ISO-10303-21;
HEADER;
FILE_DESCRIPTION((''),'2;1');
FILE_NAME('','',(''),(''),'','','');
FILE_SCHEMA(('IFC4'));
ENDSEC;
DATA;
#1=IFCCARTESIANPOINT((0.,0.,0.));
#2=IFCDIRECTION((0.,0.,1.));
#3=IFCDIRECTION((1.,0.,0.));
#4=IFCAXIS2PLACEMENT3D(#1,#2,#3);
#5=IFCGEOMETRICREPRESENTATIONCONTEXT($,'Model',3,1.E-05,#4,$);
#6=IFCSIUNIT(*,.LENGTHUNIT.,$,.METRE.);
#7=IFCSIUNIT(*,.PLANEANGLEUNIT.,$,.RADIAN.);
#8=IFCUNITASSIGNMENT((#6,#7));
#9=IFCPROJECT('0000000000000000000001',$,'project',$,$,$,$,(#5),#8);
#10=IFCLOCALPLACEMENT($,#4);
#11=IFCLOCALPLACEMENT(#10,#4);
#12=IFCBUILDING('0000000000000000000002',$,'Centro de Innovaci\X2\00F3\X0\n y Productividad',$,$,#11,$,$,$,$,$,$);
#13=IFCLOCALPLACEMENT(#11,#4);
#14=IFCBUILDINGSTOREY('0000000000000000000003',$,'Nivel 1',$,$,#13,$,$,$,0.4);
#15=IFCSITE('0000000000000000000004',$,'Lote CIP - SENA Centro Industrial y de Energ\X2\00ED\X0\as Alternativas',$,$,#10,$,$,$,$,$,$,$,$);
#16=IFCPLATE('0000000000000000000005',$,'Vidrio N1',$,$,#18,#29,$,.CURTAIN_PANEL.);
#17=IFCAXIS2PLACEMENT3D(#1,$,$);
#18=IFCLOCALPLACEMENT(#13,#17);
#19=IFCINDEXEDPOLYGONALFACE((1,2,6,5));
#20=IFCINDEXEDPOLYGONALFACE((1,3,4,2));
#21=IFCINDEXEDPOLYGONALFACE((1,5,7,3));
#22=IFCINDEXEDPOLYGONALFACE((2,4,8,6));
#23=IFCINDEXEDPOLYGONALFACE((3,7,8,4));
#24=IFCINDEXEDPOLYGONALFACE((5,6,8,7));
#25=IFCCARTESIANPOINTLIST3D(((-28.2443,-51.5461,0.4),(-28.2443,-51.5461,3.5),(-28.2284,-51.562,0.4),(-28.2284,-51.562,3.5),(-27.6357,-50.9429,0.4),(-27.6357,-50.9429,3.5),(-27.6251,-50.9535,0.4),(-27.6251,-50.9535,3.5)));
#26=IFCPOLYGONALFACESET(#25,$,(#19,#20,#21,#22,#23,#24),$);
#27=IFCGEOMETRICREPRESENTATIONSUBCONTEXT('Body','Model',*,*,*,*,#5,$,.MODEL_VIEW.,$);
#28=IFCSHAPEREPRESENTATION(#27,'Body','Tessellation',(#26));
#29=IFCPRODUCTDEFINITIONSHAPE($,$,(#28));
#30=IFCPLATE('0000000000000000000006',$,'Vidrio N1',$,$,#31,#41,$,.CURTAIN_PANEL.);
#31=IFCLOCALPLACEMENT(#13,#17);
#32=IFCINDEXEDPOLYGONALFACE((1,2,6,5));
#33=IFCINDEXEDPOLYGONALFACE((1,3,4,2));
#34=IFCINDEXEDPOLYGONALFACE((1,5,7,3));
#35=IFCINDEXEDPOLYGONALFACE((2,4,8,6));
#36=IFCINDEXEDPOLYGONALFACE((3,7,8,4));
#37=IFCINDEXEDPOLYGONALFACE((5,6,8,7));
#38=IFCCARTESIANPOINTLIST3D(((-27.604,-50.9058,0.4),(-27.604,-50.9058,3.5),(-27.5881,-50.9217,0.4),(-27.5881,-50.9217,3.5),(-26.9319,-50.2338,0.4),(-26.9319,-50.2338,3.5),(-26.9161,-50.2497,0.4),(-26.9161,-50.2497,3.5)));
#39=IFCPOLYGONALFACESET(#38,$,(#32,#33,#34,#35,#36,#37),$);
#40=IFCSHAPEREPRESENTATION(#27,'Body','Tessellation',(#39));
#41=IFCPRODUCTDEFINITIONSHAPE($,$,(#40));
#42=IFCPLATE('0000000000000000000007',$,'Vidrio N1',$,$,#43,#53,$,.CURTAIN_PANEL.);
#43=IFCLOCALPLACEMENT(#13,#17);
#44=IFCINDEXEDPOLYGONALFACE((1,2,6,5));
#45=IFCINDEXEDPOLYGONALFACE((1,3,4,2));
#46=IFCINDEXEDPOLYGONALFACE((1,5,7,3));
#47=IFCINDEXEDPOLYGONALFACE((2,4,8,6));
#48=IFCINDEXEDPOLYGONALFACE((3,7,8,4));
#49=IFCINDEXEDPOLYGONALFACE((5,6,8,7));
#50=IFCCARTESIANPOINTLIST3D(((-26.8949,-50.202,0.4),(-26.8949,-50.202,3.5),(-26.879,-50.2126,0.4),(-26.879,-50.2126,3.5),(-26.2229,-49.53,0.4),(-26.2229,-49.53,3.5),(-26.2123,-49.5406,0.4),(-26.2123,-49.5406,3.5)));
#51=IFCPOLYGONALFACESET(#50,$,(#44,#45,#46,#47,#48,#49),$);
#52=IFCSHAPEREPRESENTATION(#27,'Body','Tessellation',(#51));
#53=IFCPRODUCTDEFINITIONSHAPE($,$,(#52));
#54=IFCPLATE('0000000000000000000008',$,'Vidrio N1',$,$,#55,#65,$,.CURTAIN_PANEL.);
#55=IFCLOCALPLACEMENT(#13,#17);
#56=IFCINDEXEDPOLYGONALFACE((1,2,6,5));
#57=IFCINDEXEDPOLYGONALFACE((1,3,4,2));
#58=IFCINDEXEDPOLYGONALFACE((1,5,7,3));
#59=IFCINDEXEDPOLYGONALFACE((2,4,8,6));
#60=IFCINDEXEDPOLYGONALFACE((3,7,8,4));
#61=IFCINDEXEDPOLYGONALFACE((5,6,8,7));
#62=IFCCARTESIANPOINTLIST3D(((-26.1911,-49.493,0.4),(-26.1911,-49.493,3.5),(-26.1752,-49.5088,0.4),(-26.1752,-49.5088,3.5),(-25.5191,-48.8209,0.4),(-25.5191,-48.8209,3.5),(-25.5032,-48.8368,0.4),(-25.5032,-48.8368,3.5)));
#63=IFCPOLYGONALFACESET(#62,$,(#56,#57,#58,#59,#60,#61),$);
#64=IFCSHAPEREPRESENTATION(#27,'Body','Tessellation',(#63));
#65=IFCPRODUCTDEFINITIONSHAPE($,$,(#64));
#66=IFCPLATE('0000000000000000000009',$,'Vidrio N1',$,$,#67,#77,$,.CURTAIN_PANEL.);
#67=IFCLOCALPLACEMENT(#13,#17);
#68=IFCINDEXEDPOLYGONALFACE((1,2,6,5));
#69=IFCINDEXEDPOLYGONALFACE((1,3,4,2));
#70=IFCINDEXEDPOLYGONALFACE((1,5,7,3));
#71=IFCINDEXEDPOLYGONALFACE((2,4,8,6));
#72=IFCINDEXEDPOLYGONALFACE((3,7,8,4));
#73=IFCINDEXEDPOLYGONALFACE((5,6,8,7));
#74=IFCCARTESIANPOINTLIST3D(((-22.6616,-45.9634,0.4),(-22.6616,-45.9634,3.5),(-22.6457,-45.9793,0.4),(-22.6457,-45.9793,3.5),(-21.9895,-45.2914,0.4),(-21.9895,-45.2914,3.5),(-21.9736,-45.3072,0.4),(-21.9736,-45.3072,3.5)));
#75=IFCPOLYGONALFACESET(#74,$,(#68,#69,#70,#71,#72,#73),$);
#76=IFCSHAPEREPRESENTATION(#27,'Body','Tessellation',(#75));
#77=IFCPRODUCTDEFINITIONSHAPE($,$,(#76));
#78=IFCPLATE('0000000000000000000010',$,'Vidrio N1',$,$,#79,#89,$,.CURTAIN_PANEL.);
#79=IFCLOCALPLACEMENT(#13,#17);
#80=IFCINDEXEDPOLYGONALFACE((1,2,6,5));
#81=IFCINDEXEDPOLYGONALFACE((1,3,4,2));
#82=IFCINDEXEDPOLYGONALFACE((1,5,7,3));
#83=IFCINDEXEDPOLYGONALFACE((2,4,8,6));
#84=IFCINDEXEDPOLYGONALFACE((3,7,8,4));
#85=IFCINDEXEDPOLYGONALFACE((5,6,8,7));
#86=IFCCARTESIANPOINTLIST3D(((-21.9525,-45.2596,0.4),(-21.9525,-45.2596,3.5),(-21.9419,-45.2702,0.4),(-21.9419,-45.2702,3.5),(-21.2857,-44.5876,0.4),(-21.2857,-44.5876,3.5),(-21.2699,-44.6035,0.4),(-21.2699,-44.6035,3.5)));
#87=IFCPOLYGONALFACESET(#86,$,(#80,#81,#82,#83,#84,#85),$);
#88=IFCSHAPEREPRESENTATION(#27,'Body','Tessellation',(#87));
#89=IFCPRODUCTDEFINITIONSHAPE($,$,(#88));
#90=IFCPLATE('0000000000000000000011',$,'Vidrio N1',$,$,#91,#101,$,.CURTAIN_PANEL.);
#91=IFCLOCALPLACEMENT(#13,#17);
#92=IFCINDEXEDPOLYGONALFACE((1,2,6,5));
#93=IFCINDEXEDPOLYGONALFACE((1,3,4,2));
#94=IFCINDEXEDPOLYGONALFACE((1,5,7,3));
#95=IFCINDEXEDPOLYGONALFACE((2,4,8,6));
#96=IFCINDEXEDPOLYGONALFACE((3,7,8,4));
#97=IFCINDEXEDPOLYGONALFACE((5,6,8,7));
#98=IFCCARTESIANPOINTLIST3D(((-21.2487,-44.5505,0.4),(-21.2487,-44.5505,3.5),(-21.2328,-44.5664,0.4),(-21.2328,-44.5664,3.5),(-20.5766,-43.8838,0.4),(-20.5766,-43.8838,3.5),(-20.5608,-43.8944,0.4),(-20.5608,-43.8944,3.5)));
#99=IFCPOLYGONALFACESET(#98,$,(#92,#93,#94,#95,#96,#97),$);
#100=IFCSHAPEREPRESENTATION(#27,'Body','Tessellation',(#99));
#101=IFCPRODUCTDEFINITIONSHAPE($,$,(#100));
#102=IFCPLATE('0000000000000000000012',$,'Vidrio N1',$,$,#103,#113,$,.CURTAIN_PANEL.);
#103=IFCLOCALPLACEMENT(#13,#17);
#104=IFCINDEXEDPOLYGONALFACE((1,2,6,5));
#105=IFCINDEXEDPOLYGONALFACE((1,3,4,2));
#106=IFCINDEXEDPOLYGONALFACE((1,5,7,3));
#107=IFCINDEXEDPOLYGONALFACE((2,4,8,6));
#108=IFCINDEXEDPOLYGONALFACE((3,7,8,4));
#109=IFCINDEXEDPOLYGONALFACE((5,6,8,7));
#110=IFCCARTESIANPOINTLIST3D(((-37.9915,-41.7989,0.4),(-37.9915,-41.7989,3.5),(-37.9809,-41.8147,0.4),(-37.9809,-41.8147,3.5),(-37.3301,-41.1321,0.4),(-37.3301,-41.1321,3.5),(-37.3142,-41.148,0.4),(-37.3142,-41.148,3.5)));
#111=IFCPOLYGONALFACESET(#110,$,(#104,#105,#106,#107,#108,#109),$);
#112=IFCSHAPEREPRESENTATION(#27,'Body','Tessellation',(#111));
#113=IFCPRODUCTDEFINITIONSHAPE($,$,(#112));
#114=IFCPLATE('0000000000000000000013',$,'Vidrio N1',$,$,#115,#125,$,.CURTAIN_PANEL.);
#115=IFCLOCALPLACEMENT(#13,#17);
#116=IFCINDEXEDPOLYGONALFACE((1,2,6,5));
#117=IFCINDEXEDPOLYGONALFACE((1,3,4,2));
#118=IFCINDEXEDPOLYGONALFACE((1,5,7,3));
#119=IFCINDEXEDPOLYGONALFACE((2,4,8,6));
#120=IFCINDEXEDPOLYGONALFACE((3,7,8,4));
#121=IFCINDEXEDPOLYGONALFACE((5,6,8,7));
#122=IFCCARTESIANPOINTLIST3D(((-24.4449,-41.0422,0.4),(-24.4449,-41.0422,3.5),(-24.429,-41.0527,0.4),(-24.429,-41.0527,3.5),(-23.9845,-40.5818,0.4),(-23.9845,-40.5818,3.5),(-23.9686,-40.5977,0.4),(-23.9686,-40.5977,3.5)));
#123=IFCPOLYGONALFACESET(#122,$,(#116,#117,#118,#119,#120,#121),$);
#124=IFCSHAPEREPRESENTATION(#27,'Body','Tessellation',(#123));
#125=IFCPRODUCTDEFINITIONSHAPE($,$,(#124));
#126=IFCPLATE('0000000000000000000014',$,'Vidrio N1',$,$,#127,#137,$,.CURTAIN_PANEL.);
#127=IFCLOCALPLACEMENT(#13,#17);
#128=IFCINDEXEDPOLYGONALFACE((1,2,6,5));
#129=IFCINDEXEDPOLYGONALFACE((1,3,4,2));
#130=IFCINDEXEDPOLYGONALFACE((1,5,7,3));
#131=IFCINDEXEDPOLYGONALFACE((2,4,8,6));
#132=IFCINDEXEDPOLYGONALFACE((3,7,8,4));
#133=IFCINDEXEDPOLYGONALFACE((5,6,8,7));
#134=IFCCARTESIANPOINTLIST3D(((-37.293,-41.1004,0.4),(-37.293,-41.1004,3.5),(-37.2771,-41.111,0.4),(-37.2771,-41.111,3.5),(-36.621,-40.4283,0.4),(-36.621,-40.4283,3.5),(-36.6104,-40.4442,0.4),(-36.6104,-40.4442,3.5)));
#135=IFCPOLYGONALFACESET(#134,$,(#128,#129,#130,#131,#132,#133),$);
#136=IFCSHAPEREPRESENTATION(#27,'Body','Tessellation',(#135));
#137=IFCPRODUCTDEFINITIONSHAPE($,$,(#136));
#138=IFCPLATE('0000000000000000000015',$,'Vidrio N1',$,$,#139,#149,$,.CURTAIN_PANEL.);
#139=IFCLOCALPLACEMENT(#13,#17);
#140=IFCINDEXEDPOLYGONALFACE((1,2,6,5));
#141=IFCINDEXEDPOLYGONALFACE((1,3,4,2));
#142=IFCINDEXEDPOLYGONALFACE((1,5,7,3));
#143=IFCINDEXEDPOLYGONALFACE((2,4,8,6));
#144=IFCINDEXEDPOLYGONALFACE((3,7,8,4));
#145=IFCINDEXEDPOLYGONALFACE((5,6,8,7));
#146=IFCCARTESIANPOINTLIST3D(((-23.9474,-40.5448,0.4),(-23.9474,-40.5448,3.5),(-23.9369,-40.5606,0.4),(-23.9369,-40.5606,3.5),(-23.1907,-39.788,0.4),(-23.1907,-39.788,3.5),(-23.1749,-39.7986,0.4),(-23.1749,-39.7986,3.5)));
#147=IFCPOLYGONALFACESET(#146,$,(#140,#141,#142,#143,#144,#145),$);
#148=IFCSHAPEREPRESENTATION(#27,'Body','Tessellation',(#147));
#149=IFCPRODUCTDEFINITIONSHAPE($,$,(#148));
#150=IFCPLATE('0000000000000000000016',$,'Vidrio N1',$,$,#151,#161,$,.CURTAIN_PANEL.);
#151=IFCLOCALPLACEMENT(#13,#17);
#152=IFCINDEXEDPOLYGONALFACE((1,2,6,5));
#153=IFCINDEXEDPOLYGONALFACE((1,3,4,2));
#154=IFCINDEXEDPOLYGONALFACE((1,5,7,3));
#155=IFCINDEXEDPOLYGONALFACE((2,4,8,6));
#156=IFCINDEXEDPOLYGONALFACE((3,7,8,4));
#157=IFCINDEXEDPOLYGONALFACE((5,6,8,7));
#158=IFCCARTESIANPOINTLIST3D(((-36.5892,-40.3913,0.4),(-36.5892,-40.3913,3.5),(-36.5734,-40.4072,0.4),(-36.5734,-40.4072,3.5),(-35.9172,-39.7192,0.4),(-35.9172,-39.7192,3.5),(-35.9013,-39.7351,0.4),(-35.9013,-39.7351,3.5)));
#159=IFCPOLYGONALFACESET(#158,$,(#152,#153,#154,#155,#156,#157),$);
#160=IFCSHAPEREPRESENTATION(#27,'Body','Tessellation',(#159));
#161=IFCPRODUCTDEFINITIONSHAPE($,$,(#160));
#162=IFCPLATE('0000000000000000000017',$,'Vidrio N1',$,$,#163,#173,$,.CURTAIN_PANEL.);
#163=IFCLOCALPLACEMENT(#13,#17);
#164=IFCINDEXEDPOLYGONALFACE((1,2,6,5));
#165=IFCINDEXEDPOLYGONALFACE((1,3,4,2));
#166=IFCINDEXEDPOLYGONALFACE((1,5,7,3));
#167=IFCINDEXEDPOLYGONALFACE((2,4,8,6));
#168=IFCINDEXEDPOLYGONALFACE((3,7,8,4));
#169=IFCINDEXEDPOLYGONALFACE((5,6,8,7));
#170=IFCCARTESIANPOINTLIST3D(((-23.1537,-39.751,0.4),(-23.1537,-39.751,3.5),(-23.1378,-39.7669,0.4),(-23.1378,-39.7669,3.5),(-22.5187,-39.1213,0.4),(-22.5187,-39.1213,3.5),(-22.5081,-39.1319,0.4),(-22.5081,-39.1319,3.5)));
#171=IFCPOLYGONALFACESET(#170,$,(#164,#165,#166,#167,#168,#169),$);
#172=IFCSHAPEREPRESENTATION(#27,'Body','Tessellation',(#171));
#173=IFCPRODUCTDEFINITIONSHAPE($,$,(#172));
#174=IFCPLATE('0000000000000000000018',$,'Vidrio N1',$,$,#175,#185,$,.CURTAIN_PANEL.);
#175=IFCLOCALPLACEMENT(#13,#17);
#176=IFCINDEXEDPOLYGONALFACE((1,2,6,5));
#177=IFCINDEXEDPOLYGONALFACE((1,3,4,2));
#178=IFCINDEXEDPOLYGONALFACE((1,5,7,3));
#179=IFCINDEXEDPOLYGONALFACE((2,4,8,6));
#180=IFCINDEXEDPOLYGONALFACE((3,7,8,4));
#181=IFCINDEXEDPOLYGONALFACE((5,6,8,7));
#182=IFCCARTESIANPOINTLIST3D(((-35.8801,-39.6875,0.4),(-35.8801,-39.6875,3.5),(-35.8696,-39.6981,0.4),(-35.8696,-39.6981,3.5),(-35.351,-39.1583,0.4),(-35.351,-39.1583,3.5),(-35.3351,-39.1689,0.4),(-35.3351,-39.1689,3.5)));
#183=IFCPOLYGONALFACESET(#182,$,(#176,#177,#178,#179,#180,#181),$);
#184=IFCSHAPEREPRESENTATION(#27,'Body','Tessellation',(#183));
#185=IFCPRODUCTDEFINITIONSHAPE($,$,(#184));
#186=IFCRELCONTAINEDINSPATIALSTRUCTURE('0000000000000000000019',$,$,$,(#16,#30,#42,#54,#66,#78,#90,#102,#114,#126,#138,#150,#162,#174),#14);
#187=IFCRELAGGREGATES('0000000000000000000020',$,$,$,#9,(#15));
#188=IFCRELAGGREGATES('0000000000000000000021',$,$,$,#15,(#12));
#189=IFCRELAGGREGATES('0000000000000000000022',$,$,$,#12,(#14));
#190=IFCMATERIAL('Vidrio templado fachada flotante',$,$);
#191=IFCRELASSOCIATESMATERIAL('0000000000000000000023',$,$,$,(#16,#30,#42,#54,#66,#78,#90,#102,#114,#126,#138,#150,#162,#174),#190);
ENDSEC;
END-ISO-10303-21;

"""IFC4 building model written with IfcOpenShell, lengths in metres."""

from ifc_helpers import new_model, si_unit, frame, origin_with_axes, place, context, subcontext, project, spatial, polyline, outline, extrude, material, element, save


model = new_model("IFC4")

# Units and contexts
model_context = context("Model", 3, precision=1e-05, world=origin_with_axes())
body_context = subcontext(model_context, "Body", "Model", "MODEL_VIEW")
ifc_project = project(units=[si_unit("LENGTHUNIT", "METRE"), si_unit("PLANEANGLEUNIT", "RADIAN")], contexts=[model_context])

# Site, building, storey
site_placement = place(None, origin_with_axes())
site = spatial("IfcSite", under=ifc_project, at=site_placement, Name="Lote CIP - SENA Centro Industrial y de Energías Alternativas")
building_placement = place(site_placement, origin_with_axes())
building = spatial("IfcBuilding", under=site, at=building_placement, Name="Centro de Innovación y Productividad")
storey_placement = place(building_placement, origin_with_axes())
storey = spatial("IfcBuildingStorey", under=building, at=storey_placement, Name="Nivel 1", Elevation=0.4)

# Plates
ifc_material_1 = material(Name="Vidrio templado fachada flotante")
plate_1_placement = place(storey_placement, origin_with_axes())
element("IfcPlate", 1, at=plate_1_placement, inside=storey, material=ifc_material_1, Name="Vidrio N1", PredefinedType="CURTAIN_PANEL", context=body_context, shape_type="SweptSolid", body=[
    extrude(outline(polyline([(-27.6251, -50.9535), (-28.2284, -51.562), (-28.2443, -51.5461), (-27.6357, -50.9429), (-27.6251, -50.9535)])), frame((0.0, 0.0, 0.4)), (0.0, 0.0, 1.0), 3.1),
])
plate_2_placement = place(storey_placement, origin_with_axes())
element("IfcPlate", 2, at=plate_2_placement, inside=storey, material=ifc_material_1, Name="Vidrio N1", PredefinedType="CURTAIN_PANEL", context=body_context, shape_type="SweptSolid", body=[
    extrude(outline(polyline([(-26.9161, -50.2497), (-27.5881, -50.9217), (-27.604, -50.9058), (-26.9319, -50.2338), (-26.9161, -50.2497)])), frame((0.0, 0.0, 0.4)), (0.0, 0.0, 1.0), 3.1),
])
plate_3_placement = place(storey_placement, origin_with_axes())
element("IfcPlate", 3, at=plate_3_placement, inside=storey, material=ifc_material_1, Name="Vidrio N1", PredefinedType="CURTAIN_PANEL", context=body_context, shape_type="SweptSolid", body=[
    extrude(outline(polyline([(-26.879, -50.2126), (-26.8949, -50.202), (-26.2229, -49.53), (-26.2123, -49.5406), (-26.879, -50.2126)])), frame((0.0, 0.0, 0.4)), (0.0, 0.0, 1.0), 3.1),
])
plate_4_placement = place(storey_placement, origin_with_axes())
element("IfcPlate", 4, at=plate_4_placement, inside=storey, material=ifc_material_1, Name="Vidrio N1", PredefinedType="CURTAIN_PANEL", context=body_context, shape_type="SweptSolid", body=[
    extrude(outline(polyline([(-25.5032, -48.8368), (-26.1752, -49.5088), (-26.1911, -49.493), (-25.5191, -48.8209), (-25.5032, -48.8368)])), frame((0.0, 0.0, 0.4)), (0.0, 0.0, 1.0), 3.1),
])
plate_5_placement = place(storey_placement, origin_with_axes())
element("IfcPlate", 5, at=plate_5_placement, inside=storey, material=ifc_material_1, Name="Vidrio N1", PredefinedType="CURTAIN_PANEL", context=body_context, shape_type="SweptSolid", body=[
    extrude(outline(polyline([(-21.9736, -45.3072), (-22.6457, -45.9793), (-22.6616, -45.9634), (-21.9895, -45.2914), (-21.9736, -45.3072)])), frame((0.0, 0.0, 0.4)), (0.0, 0.0, 1.0), 3.1),
])
plate_6_placement = place(storey_placement, origin_with_axes())
element("IfcPlate", 6, at=plate_6_placement, inside=storey, material=ifc_material_1, Name="Vidrio N1", PredefinedType="CURTAIN_PANEL", context=body_context, shape_type="SweptSolid", body=[
    extrude(outline(polyline([(-21.9419, -45.2702), (-21.9525, -45.2596), (-21.2857, -44.5876), (-21.2699, -44.6035), (-21.9419, -45.2702)])), frame((0.0, 0.0, 0.4)), (0.0, 0.0, 1.0), 3.1),
])
plate_7_placement = place(storey_placement, origin_with_axes())
element("IfcPlate", 7, at=plate_7_placement, inside=storey, material=ifc_material_1, Name="Vidrio N1", PredefinedType="CURTAIN_PANEL", context=body_context, shape_type="SweptSolid", body=[
    extrude(outline(polyline([(-20.5608, -43.8944), (-21.2328, -44.5664), (-21.2487, -44.5505), (-20.5766, -43.8838), (-20.5608, -43.8944)])), frame((0.0, 0.0, 0.4)), (0.0, 0.0, 1.0), 3.1),
])
plate_8_placement = place(storey_placement, origin_with_axes())
element("IfcPlate", 8, at=plate_8_placement, inside=storey, material=ifc_material_1, Name="Vidrio N1", PredefinedType="CURTAIN_PANEL", context=body_context, shape_type="SweptSolid", body=[
    extrude(outline(polyline([(-37.3142, -41.148), (-37.9809, -41.8147), (-37.9915, -41.7989), (-37.3301, -41.1321), (-37.3142, -41.148)])), frame((0.0, 0.0, 0.4)), (0.0, 0.0, 1.0), 3.1),
])
plate_9_placement = place(storey_placement, origin_with_axes())
element("IfcPlate", 9, at=plate_9_placement, inside=storey, material=ifc_material_1, Name="Vidrio N1", PredefinedType="CURTAIN_PANEL", context=body_context, shape_type="SweptSolid", body=[
    extrude(outline(polyline([(-24.429, -41.0527), (-24.4449, -41.0422), (-23.9845, -40.5818), (-23.9686, -40.5977), (-24.429, -41.0527)])), frame((0.0, 0.0, 0.4)), (0.0, 0.0, 1.0), 3.1),
])
plate_10_placement = place(storey_placement, origin_with_axes())
element("IfcPlate", 10, at=plate_10_placement, inside=storey, material=ifc_material_1, Name="Vidrio N1", PredefinedType="CURTAIN_PANEL", context=body_context, shape_type="SweptSolid", body=[
    extrude(outline(polyline([(-36.6104, -40.4442), (-37.2771, -41.111), (-37.293, -41.1004), (-36.621, -40.4283), (-36.6104, -40.4442)])), frame((0.0, 0.0, 0.4)), (0.0, 0.0, 1.0), 3.1),
])
plate_11_placement = place(storey_placement, origin_with_axes())
element("IfcPlate", 11, at=plate_11_placement, inside=storey, material=ifc_material_1, Name="Vidrio N1", PredefinedType="CURTAIN_PANEL", context=body_context, shape_type="SweptSolid", body=[
    extrude(outline(polyline([(-23.1749, -39.7986), (-23.9369, -40.5606), (-23.9474, -40.5448), (-23.1907, -39.788), (-23.1749, -39.7986)])), frame((0.0, 0.0, 0.4)), (0.0, 0.0, 1.0), 3.1),
])
plate_12_placement = place(storey_placement, origin_with_axes())
element("IfcPlate", 12, at=plate_12_placement, inside=storey, material=ifc_material_1, Name="Vidrio N1", PredefinedType="CURTAIN_PANEL", context=body_context, shape_type="SweptSolid", body=[
    extrude(outline(polyline([(-35.9013, -39.7351), (-36.5734, -40.4072), (-36.5892, -40.3913), (-35.9172, -39.7192), (-35.9013, -39.7351)])), frame((0.0, 0.0, 0.4)), (0.0, 0.0, 1.0), 3.1),
])
plate_13_placement = place(storey_placement, origin_with_axes())
element("IfcPlate", 13, at=plate_13_placement, inside=storey, material=ifc_material_1, Name="Vidrio N1", PredefinedType="CURTAIN_PANEL", context=body_context, shape_type="SweptSolid", body=[
    extrude(outline(polyline([(-23.1378, -39.7669), (-23.1537, -39.751), (-22.5187, -39.1213), (-22.5081, -39.1319), (-23.1378, -39.7669)])), frame((0.0, 0.0, 0.4)), (0.0, 0.0, 1.0), 3.1),
])
plate_14_placement = place(storey_placement, origin_with_axes())
element("IfcPlate", 14, at=plate_14_placement, inside=storey, material=ifc_material_1, Name="Vidrio N1", PredefinedType="CURTAIN_PANEL", context=body_context, shape_type="SweptSolid", body=[
    extrude(outline(polyline([(-35.8696, -39.6981), (-35.8801, -39.6875), (-35.351, -39.1583), (-35.3351, -39.1689), (-35.8696, -39.6981)])), frame((0.0, 0.0, 0.4)), (0.0, 0.0, 1.0), 3.1),
])

save(model, "model.ifc")
